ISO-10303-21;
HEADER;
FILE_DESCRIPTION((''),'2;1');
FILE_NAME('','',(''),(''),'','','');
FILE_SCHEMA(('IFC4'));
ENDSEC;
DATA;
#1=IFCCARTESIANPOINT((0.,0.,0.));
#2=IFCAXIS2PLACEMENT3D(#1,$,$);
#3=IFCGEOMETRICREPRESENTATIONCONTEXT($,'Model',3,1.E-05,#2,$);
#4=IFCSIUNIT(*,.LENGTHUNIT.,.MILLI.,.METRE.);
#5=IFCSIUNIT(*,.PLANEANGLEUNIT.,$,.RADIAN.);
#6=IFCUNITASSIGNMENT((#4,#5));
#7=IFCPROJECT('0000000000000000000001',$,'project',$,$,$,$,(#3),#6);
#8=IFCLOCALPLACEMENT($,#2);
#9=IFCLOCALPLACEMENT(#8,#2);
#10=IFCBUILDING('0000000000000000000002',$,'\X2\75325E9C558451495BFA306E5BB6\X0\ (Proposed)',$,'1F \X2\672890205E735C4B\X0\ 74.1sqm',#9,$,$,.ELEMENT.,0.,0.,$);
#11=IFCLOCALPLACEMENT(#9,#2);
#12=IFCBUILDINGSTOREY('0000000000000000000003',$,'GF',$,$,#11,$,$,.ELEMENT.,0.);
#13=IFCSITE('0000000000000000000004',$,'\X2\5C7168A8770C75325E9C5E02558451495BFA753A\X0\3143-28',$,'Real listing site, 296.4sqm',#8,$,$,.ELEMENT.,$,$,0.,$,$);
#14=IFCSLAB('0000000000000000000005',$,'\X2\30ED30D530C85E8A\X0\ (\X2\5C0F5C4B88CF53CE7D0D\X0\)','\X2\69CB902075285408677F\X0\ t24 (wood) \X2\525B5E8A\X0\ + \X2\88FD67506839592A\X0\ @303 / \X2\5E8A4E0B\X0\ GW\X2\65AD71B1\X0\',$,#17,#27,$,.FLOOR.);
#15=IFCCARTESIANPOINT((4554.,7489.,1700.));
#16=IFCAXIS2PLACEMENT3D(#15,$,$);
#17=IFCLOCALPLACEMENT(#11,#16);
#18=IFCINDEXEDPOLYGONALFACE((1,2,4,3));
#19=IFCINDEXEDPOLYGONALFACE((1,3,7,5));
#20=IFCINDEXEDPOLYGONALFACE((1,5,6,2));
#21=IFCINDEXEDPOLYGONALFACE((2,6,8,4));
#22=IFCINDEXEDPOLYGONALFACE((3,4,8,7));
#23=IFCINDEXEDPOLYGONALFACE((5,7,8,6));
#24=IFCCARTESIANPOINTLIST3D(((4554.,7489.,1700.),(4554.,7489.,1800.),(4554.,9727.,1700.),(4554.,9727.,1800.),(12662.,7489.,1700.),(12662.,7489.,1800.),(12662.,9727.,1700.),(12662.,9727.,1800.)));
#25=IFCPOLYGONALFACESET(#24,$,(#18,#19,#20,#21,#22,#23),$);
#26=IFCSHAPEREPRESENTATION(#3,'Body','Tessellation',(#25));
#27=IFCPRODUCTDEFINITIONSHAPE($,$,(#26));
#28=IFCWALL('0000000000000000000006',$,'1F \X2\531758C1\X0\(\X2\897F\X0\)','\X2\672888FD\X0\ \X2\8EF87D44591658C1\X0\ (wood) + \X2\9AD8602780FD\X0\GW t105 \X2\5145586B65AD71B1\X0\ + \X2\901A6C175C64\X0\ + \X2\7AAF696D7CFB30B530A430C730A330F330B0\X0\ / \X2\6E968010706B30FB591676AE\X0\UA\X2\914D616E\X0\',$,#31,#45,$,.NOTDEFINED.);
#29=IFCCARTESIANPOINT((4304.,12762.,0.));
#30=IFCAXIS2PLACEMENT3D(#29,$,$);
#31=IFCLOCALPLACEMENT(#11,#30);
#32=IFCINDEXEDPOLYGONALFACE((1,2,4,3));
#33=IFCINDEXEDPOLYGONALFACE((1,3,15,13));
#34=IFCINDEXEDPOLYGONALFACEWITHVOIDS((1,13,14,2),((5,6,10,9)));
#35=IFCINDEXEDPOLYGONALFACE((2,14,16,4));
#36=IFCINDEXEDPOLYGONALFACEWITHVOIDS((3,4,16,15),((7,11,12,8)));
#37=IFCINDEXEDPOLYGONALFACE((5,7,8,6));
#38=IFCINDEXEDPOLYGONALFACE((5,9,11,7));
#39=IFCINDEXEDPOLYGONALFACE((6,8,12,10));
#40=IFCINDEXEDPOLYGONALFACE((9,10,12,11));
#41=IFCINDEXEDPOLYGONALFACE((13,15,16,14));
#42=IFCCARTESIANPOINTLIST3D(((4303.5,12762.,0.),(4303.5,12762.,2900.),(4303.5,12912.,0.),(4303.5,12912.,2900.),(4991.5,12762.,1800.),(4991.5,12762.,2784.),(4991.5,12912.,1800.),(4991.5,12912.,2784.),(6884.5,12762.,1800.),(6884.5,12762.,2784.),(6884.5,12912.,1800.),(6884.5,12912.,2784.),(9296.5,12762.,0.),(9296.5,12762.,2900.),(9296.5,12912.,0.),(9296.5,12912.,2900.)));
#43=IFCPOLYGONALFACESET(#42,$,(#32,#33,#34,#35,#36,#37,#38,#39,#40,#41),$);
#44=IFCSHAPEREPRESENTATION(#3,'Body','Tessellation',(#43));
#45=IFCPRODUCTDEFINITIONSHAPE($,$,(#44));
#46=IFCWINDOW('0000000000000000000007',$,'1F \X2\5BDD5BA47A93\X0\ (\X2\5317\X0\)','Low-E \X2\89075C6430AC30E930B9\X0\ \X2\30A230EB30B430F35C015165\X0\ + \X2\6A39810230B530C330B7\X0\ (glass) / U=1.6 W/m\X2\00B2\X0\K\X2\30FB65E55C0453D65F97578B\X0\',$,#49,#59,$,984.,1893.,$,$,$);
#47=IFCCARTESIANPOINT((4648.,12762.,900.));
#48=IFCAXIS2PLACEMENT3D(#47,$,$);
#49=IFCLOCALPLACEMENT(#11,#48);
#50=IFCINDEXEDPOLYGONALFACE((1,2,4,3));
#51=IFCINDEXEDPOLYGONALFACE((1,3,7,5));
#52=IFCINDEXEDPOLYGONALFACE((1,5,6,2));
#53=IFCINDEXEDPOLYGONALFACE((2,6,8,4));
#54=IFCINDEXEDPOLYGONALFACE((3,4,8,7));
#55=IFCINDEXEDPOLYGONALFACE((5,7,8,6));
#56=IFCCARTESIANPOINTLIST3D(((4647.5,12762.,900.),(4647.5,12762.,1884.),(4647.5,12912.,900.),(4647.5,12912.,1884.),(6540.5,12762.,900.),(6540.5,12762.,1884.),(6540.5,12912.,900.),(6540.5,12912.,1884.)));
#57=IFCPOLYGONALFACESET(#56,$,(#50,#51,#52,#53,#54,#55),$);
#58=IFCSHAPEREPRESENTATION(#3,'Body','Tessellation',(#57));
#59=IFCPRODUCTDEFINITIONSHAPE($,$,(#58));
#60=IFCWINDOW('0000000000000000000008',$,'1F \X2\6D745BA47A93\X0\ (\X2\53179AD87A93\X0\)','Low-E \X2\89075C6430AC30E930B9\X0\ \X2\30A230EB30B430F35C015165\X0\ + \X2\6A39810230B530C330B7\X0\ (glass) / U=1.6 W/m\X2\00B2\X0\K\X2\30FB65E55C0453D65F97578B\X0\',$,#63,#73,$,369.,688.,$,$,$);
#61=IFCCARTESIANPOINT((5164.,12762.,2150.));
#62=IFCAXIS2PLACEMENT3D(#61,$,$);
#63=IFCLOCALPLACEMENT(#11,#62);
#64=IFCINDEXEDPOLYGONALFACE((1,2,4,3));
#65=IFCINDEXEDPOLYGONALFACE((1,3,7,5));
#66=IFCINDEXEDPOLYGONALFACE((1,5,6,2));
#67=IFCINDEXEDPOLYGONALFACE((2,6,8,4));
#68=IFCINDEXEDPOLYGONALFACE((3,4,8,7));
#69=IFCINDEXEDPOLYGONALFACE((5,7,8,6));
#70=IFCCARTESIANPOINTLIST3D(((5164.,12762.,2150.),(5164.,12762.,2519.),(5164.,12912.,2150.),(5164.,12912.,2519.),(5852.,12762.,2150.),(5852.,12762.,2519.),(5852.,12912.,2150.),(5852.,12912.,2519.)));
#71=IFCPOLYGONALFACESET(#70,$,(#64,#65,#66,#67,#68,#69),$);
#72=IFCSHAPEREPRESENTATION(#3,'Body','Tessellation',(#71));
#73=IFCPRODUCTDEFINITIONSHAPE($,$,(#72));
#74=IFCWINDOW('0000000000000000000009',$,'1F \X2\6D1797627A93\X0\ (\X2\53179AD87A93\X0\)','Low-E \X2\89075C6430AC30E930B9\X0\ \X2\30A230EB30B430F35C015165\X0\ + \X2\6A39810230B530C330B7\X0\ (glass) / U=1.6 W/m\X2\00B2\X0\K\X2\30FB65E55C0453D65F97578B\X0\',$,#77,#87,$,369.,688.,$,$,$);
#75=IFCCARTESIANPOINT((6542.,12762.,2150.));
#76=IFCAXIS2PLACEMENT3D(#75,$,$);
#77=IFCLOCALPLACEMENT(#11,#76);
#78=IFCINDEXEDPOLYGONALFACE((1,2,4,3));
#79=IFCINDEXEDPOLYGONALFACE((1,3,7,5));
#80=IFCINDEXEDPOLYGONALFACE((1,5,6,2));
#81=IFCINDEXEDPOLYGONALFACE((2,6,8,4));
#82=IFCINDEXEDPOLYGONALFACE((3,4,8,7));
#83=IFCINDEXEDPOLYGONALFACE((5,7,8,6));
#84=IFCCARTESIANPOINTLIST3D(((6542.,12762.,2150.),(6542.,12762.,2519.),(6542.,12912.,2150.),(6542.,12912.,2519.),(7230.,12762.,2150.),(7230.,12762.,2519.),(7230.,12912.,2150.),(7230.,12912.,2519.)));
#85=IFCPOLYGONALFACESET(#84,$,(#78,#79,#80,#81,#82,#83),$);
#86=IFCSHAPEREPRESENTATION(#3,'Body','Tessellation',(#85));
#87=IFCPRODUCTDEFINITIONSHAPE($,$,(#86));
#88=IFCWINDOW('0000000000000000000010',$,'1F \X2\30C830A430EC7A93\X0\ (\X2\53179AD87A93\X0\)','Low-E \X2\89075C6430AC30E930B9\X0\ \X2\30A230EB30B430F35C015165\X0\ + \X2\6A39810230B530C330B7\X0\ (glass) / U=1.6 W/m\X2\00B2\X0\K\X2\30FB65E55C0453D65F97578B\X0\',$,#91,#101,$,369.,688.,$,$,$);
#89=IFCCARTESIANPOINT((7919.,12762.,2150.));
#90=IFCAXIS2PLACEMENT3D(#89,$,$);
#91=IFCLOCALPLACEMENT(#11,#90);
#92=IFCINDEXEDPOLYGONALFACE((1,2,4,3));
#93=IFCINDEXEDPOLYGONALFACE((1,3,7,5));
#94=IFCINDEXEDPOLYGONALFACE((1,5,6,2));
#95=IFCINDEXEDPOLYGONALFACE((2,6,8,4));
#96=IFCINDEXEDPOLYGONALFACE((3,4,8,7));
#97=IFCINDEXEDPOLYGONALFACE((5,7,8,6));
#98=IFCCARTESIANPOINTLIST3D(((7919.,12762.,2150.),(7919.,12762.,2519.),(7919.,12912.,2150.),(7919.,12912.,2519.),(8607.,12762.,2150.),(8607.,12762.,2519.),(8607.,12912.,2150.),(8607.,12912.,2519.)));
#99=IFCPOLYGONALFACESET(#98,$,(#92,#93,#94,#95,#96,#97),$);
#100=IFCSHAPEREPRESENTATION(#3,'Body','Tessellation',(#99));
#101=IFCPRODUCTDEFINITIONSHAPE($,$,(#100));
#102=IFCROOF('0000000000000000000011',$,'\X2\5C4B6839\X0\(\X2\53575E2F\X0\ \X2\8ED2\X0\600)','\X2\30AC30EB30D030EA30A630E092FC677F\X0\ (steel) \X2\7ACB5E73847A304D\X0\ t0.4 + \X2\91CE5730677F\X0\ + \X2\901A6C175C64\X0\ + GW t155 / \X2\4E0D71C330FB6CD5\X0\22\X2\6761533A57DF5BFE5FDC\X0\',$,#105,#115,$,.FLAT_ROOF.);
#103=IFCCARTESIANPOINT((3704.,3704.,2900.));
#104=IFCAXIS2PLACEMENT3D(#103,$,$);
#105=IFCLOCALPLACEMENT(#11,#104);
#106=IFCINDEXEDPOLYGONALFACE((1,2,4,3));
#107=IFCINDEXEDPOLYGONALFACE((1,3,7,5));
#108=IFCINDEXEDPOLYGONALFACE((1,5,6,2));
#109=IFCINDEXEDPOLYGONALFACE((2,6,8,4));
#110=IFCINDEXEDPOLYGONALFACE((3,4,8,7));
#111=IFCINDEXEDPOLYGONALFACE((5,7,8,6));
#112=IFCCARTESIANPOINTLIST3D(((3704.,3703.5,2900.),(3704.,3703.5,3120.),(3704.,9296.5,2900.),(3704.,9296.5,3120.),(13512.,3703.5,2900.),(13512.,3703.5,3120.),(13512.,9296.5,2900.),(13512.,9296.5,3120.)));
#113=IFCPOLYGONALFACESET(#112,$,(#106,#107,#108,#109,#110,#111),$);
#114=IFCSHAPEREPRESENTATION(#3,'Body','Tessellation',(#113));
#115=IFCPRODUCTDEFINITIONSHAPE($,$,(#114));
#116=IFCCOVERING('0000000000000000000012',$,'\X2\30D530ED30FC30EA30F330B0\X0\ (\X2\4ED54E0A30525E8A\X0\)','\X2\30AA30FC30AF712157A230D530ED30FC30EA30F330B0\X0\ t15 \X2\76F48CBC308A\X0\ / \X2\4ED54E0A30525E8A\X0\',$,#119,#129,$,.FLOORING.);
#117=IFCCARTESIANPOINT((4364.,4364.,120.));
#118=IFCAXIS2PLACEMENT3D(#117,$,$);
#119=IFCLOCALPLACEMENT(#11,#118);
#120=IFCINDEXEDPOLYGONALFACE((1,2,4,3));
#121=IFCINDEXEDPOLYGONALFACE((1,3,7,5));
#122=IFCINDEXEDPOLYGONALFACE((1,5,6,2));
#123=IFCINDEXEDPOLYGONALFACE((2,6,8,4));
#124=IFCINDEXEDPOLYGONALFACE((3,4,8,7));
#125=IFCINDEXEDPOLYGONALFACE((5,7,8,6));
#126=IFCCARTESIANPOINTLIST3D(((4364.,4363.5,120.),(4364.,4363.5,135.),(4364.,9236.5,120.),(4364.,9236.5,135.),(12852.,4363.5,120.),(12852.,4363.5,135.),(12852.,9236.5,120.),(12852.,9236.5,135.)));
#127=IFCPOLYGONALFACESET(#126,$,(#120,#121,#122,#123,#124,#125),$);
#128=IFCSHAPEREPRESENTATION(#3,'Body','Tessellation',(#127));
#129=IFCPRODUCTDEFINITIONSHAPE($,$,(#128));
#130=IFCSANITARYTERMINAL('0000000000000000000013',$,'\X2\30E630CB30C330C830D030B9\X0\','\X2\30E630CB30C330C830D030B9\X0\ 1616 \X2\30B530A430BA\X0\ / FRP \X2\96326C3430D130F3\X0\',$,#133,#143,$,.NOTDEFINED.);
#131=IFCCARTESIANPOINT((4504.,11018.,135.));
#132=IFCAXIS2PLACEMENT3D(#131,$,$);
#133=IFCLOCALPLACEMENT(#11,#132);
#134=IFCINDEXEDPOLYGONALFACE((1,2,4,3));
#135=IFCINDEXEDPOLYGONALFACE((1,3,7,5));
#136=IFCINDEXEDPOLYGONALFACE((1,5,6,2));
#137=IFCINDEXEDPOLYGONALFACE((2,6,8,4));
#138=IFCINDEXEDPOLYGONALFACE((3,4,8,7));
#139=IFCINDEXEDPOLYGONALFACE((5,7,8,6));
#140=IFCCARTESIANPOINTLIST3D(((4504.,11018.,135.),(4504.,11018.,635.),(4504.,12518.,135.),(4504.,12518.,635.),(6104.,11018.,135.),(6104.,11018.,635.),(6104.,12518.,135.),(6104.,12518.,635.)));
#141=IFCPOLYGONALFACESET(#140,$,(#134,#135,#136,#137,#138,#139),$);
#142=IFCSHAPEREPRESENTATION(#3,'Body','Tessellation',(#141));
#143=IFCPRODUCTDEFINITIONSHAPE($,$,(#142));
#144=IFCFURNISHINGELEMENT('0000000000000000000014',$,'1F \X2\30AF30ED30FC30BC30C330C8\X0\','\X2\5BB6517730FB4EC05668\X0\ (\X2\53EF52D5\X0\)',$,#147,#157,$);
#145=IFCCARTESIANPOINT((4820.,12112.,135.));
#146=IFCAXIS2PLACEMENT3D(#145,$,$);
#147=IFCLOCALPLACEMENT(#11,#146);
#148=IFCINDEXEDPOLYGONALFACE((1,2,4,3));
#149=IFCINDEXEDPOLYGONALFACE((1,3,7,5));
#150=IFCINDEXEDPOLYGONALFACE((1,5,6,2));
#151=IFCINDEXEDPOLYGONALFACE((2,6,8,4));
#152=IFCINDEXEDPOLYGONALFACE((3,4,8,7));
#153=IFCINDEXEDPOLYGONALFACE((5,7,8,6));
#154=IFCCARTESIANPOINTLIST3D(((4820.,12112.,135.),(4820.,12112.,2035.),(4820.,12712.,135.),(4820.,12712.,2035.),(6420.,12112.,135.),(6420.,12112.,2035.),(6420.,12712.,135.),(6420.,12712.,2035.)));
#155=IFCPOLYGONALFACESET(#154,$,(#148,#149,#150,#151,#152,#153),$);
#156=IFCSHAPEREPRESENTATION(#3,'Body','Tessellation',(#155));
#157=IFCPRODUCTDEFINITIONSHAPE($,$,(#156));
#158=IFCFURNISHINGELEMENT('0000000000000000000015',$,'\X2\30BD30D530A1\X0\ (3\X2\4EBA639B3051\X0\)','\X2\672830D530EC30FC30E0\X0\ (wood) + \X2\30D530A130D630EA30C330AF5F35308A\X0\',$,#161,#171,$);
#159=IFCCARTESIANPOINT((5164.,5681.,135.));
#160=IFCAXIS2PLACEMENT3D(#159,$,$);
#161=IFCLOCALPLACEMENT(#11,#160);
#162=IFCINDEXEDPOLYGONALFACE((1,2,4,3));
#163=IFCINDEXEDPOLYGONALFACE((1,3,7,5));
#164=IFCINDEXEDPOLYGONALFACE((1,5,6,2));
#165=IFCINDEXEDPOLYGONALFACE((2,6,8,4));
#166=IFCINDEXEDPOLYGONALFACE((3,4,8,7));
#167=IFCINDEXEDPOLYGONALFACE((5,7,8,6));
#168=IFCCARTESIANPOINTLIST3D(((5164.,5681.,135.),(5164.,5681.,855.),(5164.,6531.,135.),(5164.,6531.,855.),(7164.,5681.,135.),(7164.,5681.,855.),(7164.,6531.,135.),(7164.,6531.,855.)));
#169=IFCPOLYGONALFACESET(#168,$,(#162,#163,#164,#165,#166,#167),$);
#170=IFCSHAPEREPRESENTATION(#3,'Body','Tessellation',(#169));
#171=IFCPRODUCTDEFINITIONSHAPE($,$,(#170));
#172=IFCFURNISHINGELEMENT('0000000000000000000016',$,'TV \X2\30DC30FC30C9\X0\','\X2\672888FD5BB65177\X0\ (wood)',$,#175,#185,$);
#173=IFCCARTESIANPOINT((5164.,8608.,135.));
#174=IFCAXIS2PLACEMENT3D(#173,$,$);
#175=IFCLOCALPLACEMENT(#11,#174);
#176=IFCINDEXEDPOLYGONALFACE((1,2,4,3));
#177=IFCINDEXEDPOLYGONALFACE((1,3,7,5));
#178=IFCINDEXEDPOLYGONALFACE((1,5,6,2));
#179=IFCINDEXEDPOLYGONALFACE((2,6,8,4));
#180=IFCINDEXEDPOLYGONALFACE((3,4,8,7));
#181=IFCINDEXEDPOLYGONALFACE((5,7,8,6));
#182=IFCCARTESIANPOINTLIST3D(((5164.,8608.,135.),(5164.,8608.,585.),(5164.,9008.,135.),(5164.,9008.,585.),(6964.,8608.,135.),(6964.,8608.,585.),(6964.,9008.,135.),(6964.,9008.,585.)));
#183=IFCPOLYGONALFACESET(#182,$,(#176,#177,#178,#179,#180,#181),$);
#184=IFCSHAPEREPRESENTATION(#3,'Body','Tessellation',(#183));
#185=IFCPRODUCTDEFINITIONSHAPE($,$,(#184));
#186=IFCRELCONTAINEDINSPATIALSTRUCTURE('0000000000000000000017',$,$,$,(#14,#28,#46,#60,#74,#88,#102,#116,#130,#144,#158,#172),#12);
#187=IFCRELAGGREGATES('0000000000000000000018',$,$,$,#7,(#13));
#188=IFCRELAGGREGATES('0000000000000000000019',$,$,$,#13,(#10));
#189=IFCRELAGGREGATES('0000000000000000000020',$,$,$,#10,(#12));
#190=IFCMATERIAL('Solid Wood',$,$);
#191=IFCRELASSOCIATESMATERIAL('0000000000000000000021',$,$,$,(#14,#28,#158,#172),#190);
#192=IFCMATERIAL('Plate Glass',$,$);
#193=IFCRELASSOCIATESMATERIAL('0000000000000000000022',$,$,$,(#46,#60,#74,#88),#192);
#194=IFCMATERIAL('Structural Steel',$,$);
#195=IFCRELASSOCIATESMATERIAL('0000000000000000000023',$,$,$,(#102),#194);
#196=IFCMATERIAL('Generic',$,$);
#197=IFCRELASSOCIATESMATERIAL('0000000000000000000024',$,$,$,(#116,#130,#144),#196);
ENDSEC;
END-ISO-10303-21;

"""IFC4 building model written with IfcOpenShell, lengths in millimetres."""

from ifc_helpers import new_model, si_unit, frame, frame_2d, origin, place, context, project, spatial, rectangle, extrude, material, element, fill, save


model = new_model("IFC4")

# Units and contexts
model_context = context("Model", 3, precision=1e-05, world=origin())
ifc_project = project(units=[si_unit("LENGTHUNIT", "METRE", prefix="MILLI"), si_unit("PLANEANGLEUNIT", "RADIAN")], contexts=[model_context])

# Site, building, storey
site_placement = place(None, origin())
site = spatial("IfcSite", under=ifc_project, at=site_placement, Name="山梨県甲府市善光寺町3143-28", ObjectType="Real listing site, 296.4sqm", CompositionType="ELEMENT", RefElevation=0.0)
building_placement = place(site_placement, origin())
building = spatial("IfcBuilding", under=site, at=building_placement, Name="甲府善光寺の家 (Proposed)", ObjectType="1F 木造平屋 74.1sqm", CompositionType="ELEMENT", ElevationOfRefHeight=0.0, ElevationOfTerrain=0.0)
storey_placement = place(building_placement, origin())
storey = spatial("IfcBuildingStorey", under=building, at=storey_placement, Name="GF", CompositionType="ELEMENT", Elevation=0.0)

# Slab
ifc_material_1 = material(Name="Solid Wood")
slab_1_placement = place(storey_placement, frame((4554.0, 7489.0, 1700.0)))
element("IfcSlab", 1, at=slab_1_placement, inside=storey, material=ifc_material_1, Name="ロフト床 (小屋裏収納)", Description="構造用合板 t24 (wood) 剛床 + 製材根太 @303 / 床下 GW断熱", PredefinedType="FLOOR", context=model_context, shape_type="SweptSolid", body=[
    extrude(rectangle(XDim=8108.0, YDim=2238.0, at=frame_2d((4054.0, 1119.0))), frame((4554.0, 7489.0, 1700.0)), (0.0, 0.0, 1.0), 100.0),
])

# Shared definitions
ifc_material_2 = material(Name="Plate Glass")

# Wall, openings, windows
wall_1_placement = place(storey_placement, frame((4304.0, 12762.0, 0.0)))
wall_1 = element("IfcWall", 2, at=wall_1_placement, inside=storey, material=ifc_material_1, Name="1F 北壁(西)", Description="木製 軸組外壁 (wood) + 高性能GW t105 充填断熱 + 通気層 + 窯業系サイディング / 準耐火・外皮UA配慮", PredefinedType="NOTDEFINED", context=model_context, shape_type="SweptSolid", body=[
    extrude(rectangle(XDim=4993.0, YDim=150.0, at=frame_2d((2496.0, 75.0))), frame((4304.0, 12762.0, 0.0)), (0.0, 0.0, 1.0), 2900.0),
])
opening_1_placement = place(storey_placement, frame((4648.0, 12762.0, 900.0)))
opening_1 = element("IfcOpeningElement", 3, at=opening_1_placement, cuts=wall_1, PredefinedType="NOTDEFINED", context=model_context, shape_type="SweptSolid", body=[
    extrude(rectangle(XDim=1893.0, YDim=150.0, at=frame_2d((946.0, 75.0))), frame((4648.0, 12762.0, 900.0)), (0.0, 0.0, 1.0), 984.0),
])
opening_2_placement = place(storey_placement, frame((5164.0, 12762.0, 2150.0)))
opening_2 = element("IfcOpeningElement", 4, at=opening_2_placement, cuts=wall_1, PredefinedType="NOTDEFINED", context=model_context, shape_type="SweptSolid", body=[
    extrude(rectangle(XDim=688.0, YDim=150.0, at=frame_2d((344.0, 75.0))), frame((5164.0, 12762.0, 2150.0)), (0.0, 0.0, 1.0), 369.0),
])
opening_3_placement = place(storey_placement, frame((6542.0, 12762.0, 2150.0)))
opening_3 = element("IfcOpeningElement", 5, at=opening_3_placement, cuts=wall_1, PredefinedType="NOTDEFINED", context=model_context, shape_type="SweptSolid", body=[
    extrude(rectangle(XDim=688.0, YDim=150.0, at=frame_2d((344.0, 75.0))), frame((6542.0, 12762.0, 2150.0)), (0.0, 0.0, 1.0), 369.0),
])
opening_4_placement = place(storey_placement, frame((7919.0, 12762.0, 2150.0)))
opening_4 = element("IfcOpeningElement", 6, at=opening_4_placement, cuts=wall_1, PredefinedType="NOTDEFINED", context=model_context, shape_type="SweptSolid", body=[
    extrude(rectangle(XDim=688.0, YDim=150.0, at=frame_2d((344.0, 75.0))), frame((7919.0, 12762.0, 2150.0)), (0.0, 0.0, 1.0), 369.0),
])
window_1_placement = place(storey_placement, frame((4648.0, 12762.0, 900.0)))
window_1 = element("IfcWindow", 7, at=window_1_placement, inside=storey, material=ifc_material_2, Name="1F 寝室窓 (北)", Description="Low-E 複層ガラス アルゴン封入 + 樹脂サッシ (glass) / U=1.6 W/m²K・日射取得型", OverallHeight=984.0, OverallWidth=1893.0, context=model_context, shape_type="SweptSolid", body=[
    extrude(rectangle(XDim=1893.0, YDim=150.0, at=frame_2d((946.0, 75.0))), frame((4648.0, 12762.0, 900.0)), (0.0, 0.0, 1.0), 984.0),
])
fill(opening_1, window_1)
window_2_placement = place(storey_placement, frame((5164.0, 12762.0, 2150.0)))
window_2 = element("IfcWindow", 8, at=window_2_placement, inside=storey, material=ifc_material_2, Name="1F 浴室窓 (北高窓)", Description="Low-E 複層ガラス アルゴン封入 + 樹脂サッシ (glass) / U=1.6 W/m²K・日射取得型", OverallHeight=369.0, OverallWidth=688.0, context=model_context, shape_type="SweptSolid", body=[
    extrude(rectangle(XDim=688.0, YDim=150.0, at=frame_2d((344.0, 75.0))), frame((5164.0, 12762.0, 2150.0)), (0.0, 0.0, 1.0), 369.0),
])
fill(opening_2, window_2)
window_3_placement = place(storey_placement, frame((6542.0, 12762.0, 2150.0)))
window_3 = element("IfcWindow", 9, at=window_3_placement, inside=storey, material=ifc_material_2, Name="1F 洗面窓 (北高窓)", Description="Low-E 複層ガラス アルゴン封入 + 樹脂サッシ (glass) / U=1.6 W/m²K・日射取得型", OverallHeight=369.0, OverallWidth=688.0, context=model_context, shape_type="SweptSolid", body=[
    extrude(rectangle(XDim=688.0, YDim=150.0, at=frame_2d((344.0, 75.0))), frame((6542.0, 12762.0, 2150.0)), (0.0, 0.0, 1.0), 369.0),
])
fill(opening_3, window_3)
window_4_placement = place(storey_placement, frame((7919.0, 12762.0, 2150.0)))
window_4 = element("IfcWindow", 10, at=window_4_placement, inside=storey, material=ifc_material_2, Name="1F トイレ窓 (北高窓)", Description="Low-E 複層ガラス アルゴン封入 + 樹脂サッシ (glass) / U=1.6 W/m²K・日射取得型", OverallHeight=369.0, OverallWidth=688.0, context=model_context, shape_type="SweptSolid", body=[
    extrude(rectangle(XDim=688.0, YDim=150.0, at=frame_2d((344.0, 75.0))), frame((7919.0, 12762.0, 2150.0)), (0.0, 0.0, 1.0), 369.0),
])
fill(opening_4, window_4)

# Roof
ifc_material_3 = material(Name="Structural Steel")
roof_1_placement = place(storey_placement, frame((3704.0, 3704.0, 2900.0)))
element("IfcRoof", 11, at=roof_1_placement, inside=storey, material=ifc_material_3, Name="屋根(南帯 軒600)", Description="ガルバリウム鋼板 (steel) 立平葺き t0.4 + 野地板 + 通気層 + GW t155 / 不燃・法22条区域対応", PredefinedType="FLAT_ROOF", context=model_context, shape_type="SweptSolid", body=[
    extrude(rectangle(XDim=9808.0, YDim=5593.0, at=frame_2d((4904.0, 2796.0))), frame((3704.0, 3704.0, 2900.0)), (0.0, 0.0, 1.0), 220.0),
])

# Covering
ifc_material_4 = material(Name="Generic")
covering_1_placement = place(storey_placement, frame((4364.0, 4364.0, 120.0)))
element("IfcCovering", 12, at=covering_1_placement, inside=storey, material=ifc_material_4, Name="フローリング (仕上げ床)", Description="オーク無垢フローリング t15 直貼り / 仕上げ床", PredefinedType="FLOORING", context=model_context, shape_type="SweptSolid", body=[
    extrude(rectangle(XDim=8488.0, YDim=4873.0, at=frame_2d((4244.0, 2436.0))), frame((4364.0, 4364.0, 120.0)), (0.0, 0.0, 1.0), 15.0),
])

# Sanitary terminal
sanitary_terminal_placement = place(storey_placement, frame((4504.0, 11018.0, 135.0)))
element("IfcSanitaryTerminal", 13, at=sanitary_terminal_placement, inside=storey, material=ifc_material_4, Name="ユニットバス", Description="ユニットバス 1616 サイズ / FRP 防水パン", PredefinedType="NOTDEFINED", context=model_context, shape_type="SweptSolid", body=[
    extrude(rectangle(XDim=1600.0, YDim=1500.0, at=frame_2d((800.0, 750.0))), frame((4504.0, 11018.0, 135.0)), (0.0, 0.0, 1.0), 500.0),
])

# Furnishing elements
furnishing_1_placement = place(storey_placement, frame((4820.0, 12112.0, 135.0)))
element("IfcFurnishingElement", 14, at=furnishing_1_placement, inside=storey, material=ifc_material_4, Name="1F クローゼット", Description="家具・什器 (可動)", context=model_context, shape_type="SweptSolid", body=[
    extrude(rectangle(XDim=1600.0, YDim=600.0, at=frame_2d((800.0, 300.0))), frame((4820.0, 12112.0, 135.0)), (0.0, 0.0, 1.0), 1900.0),
])
furnishing_2_placement = place(storey_placement, frame((5164.0, 5681.0, 135.0)))
element("IfcFurnishingElement", 15, at=furnishing_2_placement, inside=storey, material=ifc_material_1, Name="ソファ (3人掛け)", Description="木フレーム (wood) + ファブリック張り", context=model_context, shape_type="SweptSolid", body=[
    extrude(rectangle(XDim=2000.0, YDim=850.0, at=frame_2d((1000.0, 425.0))), frame((5164.0, 5681.0, 135.0)), (0.0, 0.0, 1.0), 720.0),
])
furnishing_3_placement = place(storey_placement, frame((5164.0, 8608.0, 135.0)))
element("IfcFurnishingElement", 16, at=furnishing_3_placement, inside=storey, material=ifc_material_1, Name="TV ボード", Description="木製家具 (wood)", context=model_context, shape_type="SweptSolid", body=[
    extrude(rectangle(XDim=1800.0, YDim=400.0, at=frame_2d((900.0, 200.0))), frame((5164.0, 8608.0, 135.0)), (0.0, 0.0, 1.0), 450.0),
])

save(model, "model.ifc")
